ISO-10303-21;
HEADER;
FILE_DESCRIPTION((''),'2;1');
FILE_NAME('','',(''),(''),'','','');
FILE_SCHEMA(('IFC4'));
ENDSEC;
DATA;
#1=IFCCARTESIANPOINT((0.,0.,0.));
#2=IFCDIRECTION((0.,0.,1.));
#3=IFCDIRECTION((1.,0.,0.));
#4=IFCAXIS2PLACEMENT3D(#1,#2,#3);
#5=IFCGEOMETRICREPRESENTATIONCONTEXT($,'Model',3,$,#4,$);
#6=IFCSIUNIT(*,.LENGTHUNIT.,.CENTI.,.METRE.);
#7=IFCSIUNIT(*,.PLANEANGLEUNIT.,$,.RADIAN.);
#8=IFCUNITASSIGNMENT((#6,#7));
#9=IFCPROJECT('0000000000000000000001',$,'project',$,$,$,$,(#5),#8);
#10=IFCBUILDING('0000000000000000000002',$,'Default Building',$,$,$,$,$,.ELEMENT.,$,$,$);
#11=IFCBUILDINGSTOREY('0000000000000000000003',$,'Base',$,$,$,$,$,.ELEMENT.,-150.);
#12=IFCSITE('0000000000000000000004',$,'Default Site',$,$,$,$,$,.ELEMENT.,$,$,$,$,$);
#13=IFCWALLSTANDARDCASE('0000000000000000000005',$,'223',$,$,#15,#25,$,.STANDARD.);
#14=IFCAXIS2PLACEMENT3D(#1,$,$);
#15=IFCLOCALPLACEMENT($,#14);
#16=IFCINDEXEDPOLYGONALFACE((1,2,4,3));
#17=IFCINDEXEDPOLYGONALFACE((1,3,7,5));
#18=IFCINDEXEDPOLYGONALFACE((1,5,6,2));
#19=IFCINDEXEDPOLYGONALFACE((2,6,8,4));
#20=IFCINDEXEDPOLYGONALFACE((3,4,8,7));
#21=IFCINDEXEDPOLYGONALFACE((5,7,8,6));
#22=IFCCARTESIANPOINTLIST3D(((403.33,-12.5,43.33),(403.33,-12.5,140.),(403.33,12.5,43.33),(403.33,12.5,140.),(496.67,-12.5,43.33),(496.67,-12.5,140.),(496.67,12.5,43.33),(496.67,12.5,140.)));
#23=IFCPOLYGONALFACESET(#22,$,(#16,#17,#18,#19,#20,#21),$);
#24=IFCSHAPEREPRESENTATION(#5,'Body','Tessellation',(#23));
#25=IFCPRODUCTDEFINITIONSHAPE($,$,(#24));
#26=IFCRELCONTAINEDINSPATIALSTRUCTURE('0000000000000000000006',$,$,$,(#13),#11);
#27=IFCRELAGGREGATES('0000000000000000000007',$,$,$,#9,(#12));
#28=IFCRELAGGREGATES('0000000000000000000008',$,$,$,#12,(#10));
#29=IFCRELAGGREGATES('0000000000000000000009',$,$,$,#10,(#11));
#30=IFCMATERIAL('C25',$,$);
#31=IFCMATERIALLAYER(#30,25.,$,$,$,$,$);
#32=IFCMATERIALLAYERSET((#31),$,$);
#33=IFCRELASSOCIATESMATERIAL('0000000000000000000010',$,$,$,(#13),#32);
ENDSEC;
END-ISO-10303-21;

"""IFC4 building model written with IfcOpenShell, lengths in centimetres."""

from ifc_helpers import new_model, si_unit, frame, origin_with_axes, origin_2d_with_axis, place, context, project, spatial, rectangle, extrude, material, layer, layer_set, layer_usage, element, save


model = new_model("IFC4")

# Units and contexts
model_context = context("Model", 3, world=origin_with_axes())
ifc_project = project(units=[si_unit("LENGTHUNIT", "METRE", prefix="CENTI"), si_unit("PLANEANGLEUNIT", "RADIAN")], contexts=[model_context])

# Site, building, storey
site = spatial("IfcSite", under=ifc_project, Name="Default Site", CompositionType="ELEMENT")
building = spatial("IfcBuilding", under=site, Name="Default Building", CompositionType="ELEMENT")
storey = spatial("IfcBuildingStorey", under=building, Name="Base", CompositionType="ELEMENT", Elevation=-150.0)

# Shared definitions
ifc_material = material(Name="C25")

# Wall
ifc_layer_1 = layer(ifc_material, 25.0)
ifc_layer_set_1 = layer_set([ifc_layer_1])
ifc_layer_usage_1 = layer_usage(ifc_layer_set_1, "AXIS2", "POSITIVE", -25.0)
wall_1_placement = place(None, frame((450.0, 0.0, 43.33), z_axis=(0.0, 0.0, 1.0), x_axis=(-1.0, 0.0, 0.0)))
element("IfcWallStandardCase", 1, at=wall_1_placement, inside=storey, material=ifc_layer_usage_1, Name="223", PredefinedType="STANDARD", context=model_context, shape_type="SweptSolid", body=[
    extrude(rectangle(XDim=93.33, YDim=25.0, at=origin_2d_with_axis()), origin_with_axes(), (0.0, 0.0, 1.0), 96.67),
])

save(model, "model.ifc")
